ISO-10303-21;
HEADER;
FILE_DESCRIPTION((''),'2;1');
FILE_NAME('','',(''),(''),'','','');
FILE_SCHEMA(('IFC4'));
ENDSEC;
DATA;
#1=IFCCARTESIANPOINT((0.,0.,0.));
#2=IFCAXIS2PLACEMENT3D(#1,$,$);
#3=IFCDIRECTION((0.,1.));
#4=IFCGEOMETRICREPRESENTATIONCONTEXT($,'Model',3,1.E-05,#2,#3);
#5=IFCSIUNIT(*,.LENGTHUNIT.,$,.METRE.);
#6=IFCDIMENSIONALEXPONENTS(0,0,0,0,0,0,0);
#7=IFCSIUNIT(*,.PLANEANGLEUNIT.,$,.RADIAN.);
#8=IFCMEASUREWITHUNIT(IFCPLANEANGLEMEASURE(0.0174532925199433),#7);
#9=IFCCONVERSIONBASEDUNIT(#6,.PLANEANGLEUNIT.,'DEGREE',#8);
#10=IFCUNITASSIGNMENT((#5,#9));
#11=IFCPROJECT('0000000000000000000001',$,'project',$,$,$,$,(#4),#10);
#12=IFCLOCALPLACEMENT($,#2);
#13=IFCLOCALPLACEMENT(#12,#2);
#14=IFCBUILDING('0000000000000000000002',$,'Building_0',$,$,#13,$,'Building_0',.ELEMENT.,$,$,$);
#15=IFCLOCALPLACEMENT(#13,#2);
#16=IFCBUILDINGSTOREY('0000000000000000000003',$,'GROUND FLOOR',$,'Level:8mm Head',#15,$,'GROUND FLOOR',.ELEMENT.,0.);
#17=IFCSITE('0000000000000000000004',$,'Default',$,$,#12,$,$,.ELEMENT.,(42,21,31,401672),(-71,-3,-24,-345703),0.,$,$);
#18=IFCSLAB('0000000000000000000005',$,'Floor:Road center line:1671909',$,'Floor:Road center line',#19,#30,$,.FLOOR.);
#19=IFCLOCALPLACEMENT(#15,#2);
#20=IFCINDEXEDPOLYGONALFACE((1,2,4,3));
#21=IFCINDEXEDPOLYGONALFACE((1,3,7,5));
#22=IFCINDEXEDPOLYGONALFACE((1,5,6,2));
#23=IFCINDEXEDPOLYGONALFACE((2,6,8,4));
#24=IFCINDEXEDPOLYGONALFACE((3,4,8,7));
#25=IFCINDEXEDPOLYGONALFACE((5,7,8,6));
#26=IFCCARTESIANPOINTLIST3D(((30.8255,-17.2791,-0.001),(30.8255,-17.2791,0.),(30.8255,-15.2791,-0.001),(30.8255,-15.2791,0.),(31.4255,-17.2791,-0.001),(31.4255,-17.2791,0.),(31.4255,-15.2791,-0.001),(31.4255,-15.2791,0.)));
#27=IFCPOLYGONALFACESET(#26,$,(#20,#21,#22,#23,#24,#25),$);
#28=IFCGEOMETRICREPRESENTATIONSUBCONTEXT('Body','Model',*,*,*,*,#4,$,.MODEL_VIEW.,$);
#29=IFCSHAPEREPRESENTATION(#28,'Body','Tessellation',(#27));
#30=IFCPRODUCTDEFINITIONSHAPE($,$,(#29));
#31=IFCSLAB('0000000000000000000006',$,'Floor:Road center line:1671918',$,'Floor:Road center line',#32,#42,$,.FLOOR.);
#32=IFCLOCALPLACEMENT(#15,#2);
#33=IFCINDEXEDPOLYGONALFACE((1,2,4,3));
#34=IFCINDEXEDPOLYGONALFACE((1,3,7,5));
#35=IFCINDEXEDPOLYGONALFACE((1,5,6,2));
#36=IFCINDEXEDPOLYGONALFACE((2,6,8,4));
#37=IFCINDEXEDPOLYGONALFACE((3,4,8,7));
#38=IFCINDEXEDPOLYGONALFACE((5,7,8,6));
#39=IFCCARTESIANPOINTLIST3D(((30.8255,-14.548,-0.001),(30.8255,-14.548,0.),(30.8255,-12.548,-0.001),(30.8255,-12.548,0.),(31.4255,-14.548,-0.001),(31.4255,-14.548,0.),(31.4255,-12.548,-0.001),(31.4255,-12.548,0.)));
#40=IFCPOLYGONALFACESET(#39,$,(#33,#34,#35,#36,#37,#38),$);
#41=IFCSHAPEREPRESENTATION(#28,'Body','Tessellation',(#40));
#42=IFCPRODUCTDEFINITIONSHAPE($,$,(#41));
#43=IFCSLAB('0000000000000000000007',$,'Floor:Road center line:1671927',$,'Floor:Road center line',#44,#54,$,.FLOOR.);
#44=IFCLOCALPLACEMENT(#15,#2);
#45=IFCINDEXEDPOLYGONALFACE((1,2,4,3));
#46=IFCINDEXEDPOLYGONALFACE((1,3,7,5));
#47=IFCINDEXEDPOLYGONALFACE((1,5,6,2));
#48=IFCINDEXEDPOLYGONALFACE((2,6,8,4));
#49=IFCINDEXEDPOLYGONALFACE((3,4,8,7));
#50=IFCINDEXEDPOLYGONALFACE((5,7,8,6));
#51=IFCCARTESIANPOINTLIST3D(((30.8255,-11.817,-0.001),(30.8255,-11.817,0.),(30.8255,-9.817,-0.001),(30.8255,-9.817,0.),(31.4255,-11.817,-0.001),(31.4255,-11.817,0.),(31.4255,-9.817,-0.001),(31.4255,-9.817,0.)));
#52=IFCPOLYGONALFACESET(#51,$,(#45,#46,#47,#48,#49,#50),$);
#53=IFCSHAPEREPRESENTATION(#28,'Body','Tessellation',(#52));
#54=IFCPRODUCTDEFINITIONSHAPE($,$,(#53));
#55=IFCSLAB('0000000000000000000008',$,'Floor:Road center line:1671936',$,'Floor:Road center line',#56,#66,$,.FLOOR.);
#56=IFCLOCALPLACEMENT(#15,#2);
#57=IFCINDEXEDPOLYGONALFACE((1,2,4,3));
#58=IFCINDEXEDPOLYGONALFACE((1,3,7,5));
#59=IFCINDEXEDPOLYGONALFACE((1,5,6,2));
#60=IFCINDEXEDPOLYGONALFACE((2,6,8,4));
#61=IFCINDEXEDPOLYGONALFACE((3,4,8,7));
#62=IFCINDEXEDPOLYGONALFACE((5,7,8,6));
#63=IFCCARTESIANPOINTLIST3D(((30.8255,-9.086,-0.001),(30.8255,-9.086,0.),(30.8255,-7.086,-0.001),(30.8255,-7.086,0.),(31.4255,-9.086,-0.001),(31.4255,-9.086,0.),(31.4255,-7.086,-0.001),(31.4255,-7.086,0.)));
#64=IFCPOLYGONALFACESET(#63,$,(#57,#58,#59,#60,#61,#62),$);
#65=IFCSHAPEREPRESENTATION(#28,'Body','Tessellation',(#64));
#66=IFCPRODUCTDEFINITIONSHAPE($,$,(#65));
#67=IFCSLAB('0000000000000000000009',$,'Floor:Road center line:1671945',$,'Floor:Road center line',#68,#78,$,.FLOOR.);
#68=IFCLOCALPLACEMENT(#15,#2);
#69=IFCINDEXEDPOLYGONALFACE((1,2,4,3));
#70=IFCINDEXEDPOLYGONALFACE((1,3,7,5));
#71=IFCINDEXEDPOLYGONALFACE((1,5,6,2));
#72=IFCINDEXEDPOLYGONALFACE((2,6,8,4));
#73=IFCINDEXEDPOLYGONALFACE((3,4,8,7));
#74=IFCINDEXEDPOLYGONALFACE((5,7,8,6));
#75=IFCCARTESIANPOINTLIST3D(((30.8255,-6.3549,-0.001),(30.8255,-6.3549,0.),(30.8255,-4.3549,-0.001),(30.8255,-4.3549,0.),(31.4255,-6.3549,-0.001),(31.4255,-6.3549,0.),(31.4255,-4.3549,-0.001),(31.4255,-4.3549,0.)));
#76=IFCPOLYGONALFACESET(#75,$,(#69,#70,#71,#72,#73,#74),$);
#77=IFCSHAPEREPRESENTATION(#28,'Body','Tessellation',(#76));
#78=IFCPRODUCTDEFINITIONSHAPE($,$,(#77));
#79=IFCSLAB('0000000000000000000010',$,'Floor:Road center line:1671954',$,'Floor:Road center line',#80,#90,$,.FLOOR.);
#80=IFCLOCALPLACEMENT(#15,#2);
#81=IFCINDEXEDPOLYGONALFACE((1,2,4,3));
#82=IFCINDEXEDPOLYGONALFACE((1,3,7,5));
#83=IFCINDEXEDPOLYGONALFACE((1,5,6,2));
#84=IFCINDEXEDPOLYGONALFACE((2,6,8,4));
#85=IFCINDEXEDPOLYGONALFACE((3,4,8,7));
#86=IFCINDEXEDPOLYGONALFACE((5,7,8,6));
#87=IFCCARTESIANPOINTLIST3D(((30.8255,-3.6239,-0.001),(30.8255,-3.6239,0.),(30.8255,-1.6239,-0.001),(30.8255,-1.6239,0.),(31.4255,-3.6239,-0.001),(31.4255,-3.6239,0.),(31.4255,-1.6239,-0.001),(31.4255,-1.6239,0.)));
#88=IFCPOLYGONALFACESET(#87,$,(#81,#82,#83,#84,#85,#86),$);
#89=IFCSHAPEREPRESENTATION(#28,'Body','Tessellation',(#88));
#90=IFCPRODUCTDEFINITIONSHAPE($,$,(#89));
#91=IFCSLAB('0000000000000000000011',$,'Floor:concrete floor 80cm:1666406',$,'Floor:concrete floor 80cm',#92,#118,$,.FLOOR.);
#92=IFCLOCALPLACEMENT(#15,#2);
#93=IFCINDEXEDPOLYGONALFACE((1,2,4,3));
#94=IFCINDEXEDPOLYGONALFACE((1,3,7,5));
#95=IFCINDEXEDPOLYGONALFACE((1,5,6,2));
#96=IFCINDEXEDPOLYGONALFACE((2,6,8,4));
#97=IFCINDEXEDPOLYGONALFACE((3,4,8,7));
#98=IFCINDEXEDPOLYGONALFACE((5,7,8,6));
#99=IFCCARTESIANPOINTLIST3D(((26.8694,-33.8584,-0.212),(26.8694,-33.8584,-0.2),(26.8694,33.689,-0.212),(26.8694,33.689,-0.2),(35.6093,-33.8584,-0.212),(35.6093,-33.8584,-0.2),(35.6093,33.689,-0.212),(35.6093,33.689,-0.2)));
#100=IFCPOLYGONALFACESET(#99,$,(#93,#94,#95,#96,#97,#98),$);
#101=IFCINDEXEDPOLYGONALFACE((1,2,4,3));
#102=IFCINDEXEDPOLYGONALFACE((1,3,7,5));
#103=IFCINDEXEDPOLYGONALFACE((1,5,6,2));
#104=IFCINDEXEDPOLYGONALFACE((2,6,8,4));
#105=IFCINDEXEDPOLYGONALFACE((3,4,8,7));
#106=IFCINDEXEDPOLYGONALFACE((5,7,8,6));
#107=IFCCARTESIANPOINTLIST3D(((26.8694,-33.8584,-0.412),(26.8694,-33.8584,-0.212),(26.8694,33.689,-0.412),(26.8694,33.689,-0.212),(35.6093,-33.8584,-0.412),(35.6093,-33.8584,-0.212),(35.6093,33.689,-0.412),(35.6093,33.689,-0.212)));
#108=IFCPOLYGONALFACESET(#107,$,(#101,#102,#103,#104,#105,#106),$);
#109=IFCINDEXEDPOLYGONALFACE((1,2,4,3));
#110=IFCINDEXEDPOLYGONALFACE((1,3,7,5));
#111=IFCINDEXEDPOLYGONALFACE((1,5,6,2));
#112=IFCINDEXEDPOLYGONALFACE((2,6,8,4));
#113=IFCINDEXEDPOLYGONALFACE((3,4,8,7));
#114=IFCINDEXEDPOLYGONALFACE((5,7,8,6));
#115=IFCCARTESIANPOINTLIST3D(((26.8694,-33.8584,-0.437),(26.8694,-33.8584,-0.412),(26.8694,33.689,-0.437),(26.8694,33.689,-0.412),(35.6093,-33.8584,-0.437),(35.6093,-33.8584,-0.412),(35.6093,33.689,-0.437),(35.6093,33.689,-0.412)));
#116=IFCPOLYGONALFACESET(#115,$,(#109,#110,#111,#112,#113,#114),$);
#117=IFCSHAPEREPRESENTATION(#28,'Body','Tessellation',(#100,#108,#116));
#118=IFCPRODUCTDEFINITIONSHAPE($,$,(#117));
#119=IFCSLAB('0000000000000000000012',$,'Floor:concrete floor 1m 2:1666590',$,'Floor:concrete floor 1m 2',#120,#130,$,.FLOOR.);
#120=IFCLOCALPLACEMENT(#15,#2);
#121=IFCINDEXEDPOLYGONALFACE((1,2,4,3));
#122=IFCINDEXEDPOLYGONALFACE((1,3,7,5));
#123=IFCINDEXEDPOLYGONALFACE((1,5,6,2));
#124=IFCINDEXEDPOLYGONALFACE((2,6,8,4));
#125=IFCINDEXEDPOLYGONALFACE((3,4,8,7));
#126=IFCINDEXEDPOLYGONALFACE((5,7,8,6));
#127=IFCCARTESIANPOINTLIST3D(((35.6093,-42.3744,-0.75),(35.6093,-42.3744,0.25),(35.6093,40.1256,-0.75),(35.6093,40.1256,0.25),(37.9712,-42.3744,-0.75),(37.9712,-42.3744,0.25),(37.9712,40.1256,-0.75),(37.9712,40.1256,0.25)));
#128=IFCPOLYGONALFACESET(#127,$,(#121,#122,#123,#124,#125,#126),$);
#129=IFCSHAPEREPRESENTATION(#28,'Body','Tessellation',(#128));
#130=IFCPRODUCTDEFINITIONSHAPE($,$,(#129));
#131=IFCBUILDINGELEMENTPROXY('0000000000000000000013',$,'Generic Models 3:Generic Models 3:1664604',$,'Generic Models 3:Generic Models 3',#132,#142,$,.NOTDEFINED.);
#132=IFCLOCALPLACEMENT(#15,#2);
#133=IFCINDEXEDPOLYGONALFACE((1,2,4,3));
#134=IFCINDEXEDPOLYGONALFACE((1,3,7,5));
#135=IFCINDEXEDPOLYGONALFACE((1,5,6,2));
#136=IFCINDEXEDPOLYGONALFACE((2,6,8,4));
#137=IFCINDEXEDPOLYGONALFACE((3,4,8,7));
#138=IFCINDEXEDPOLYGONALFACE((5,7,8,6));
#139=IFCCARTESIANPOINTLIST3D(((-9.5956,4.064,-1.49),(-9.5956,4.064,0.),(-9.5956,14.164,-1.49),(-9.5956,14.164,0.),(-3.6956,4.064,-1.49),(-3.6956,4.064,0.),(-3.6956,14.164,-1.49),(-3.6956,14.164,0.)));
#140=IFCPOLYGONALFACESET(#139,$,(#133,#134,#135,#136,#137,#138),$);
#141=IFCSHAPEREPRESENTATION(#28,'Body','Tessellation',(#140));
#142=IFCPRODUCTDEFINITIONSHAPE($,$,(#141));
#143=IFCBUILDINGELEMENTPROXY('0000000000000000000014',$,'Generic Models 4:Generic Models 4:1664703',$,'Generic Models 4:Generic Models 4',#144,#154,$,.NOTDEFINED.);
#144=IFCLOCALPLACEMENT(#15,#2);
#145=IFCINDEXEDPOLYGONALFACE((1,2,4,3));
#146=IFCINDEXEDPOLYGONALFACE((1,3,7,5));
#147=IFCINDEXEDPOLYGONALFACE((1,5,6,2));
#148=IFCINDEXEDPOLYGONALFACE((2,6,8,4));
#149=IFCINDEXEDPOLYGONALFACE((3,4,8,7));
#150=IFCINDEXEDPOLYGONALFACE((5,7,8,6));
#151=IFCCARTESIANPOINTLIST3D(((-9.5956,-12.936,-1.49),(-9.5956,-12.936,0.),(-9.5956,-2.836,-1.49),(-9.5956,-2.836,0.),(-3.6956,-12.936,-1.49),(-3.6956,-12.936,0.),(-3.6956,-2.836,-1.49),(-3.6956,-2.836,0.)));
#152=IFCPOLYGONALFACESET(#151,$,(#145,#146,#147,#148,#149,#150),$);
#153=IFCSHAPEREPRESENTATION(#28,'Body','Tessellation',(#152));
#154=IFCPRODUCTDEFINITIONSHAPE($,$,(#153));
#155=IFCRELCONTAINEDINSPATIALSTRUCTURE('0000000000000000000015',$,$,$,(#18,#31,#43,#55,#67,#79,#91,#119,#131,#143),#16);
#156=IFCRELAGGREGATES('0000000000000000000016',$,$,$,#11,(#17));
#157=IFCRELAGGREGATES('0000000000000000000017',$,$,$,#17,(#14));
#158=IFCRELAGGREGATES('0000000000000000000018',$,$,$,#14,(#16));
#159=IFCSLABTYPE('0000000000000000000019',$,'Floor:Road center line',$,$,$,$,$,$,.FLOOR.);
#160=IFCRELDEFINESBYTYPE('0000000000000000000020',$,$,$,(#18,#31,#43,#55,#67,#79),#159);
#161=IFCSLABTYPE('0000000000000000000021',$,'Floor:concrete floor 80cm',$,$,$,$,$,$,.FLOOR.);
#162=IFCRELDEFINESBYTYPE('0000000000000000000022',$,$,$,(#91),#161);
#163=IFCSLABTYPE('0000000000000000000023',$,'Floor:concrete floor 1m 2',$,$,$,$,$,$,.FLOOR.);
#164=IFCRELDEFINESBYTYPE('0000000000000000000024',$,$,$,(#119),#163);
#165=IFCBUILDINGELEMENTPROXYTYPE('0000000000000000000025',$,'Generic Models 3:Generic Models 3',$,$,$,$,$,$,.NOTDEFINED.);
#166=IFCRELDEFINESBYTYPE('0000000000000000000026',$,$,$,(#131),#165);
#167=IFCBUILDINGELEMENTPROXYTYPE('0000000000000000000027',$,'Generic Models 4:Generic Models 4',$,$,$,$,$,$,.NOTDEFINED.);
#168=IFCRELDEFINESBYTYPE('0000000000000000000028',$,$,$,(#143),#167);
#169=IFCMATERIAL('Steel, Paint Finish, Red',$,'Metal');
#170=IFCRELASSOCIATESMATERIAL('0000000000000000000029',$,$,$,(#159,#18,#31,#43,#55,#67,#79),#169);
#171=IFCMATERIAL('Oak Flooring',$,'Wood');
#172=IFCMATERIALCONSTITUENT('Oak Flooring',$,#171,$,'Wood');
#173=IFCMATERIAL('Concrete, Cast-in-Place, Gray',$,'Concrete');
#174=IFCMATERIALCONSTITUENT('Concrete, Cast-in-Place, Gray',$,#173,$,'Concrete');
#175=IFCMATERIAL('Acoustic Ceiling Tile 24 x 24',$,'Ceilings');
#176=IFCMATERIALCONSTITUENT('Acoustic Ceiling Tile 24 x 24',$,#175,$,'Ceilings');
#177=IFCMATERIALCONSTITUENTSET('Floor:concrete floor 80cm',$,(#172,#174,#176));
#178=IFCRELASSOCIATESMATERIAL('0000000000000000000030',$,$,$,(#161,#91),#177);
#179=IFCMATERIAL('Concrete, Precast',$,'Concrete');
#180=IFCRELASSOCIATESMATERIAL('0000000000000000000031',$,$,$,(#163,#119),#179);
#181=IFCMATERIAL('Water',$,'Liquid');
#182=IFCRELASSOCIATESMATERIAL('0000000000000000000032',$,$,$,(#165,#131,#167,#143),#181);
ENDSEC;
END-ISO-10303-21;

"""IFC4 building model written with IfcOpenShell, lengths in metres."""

from ifc_helpers import new_model, entity, si_unit, converted_unit, direction, frame, origin, place, context, subcontext, project, spatial, indexed_curve, outline, extrude, source, transform, mapped, material, constituent, constituent_set, type_object, type_shapes, element, save


model = new_model("IFC4")

# Units and contexts
model_context = context("Model", 3, precision=1e-05, world=origin(), true_north=direction((0.0, 1.0)))
body_context = subcontext(model_context, "Body", "Model", "MODEL_VIEW")
ifc_project = project(units=[si_unit("LENGTHUNIT", "METRE"), converted_unit("PLANEANGLEUNIT", "DEGREE", entity("IfcPlaneAngleMeasure", 0.0174532925199433), si_unit("PLANEANGLEUNIT", "RADIAN"), dimensions=[0, 0, 0, 0, 0, 0, 0])], contexts=[model_context])

# Site, building, storey
site_placement = place(None, origin())
site = spatial("IfcSite", under=ifc_project, at=site_placement, Name="Default", CompositionType="ELEMENT", RefLatitude=(42, 21, 31, 401672), RefLongitude=(-71, -3, -24, -345703), RefElevation=0.0)
building_placement = place(site_placement, origin())
building = spatial("IfcBuilding", under=site, at=building_placement, Name="Building_0", LongName="Building_0", CompositionType="ELEMENT")
storey_placement = place(building_placement, origin())
storey = spatial("IfcBuildingStorey", under=building, at=storey_placement, Name="GROUND FLOOR", ObjectType="Level:8mm Head", LongName="GROUND FLOOR", CompositionType="ELEMENT", Elevation=0.0)

# Slabs
ifc_material_1 = material(Name="Steel, Paint Finish, Red", Category="Metal")
slab_type_1 = type_object("IfcSlabType", Name="Floor:Road center line", PredefinedType="FLOOR", material=ifc_material_1)
slab_1_placement = place(storey_placement, origin())
element("IfcSlab", 1, at=slab_1_placement, inside=storey, type_object=slab_type_1, material=ifc_material_1, Name="Floor:Road center line:1671909", ObjectType="Floor:Road center line", PredefinedType="FLOOR", context=body_context, shape_type="SweptSolid", body=[
    extrude(outline(indexed_curve([(-1.0, -0.3), (1.0, -0.3), (1.0, 0.3), (-1.0, 0.3), (-1.0, -0.3)], self_intersect=False)), frame((31.1255, -16.2791, 0.0), z_axis=(0.0, 0.0, -1.0), x_axis=(0.0, 1.0, 0.0)), (0.0, 0.0, 1.0), 0.001),
])
slab_2_placement = place(storey_placement, origin())
element("IfcSlab", 2, at=slab_2_placement, inside=storey, type_object=slab_type_1, material=ifc_material_1, Name="Floor:Road center line:1671918", ObjectType="Floor:Road center line", PredefinedType="FLOOR", context=body_context, shape_type="SweptSolid", body=[
    extrude(outline(indexed_curve([(-1.0, -0.3), (1.0, -0.3), (1.0, 0.3), (-1.0, 0.3), (-1.0, -0.3)], self_intersect=False)), frame((31.1255, -13.548, 0.0), z_axis=(0.0, 0.0, -1.0), x_axis=(0.0, 1.0, 0.0)), (0.0, 0.0, 1.0), 0.001),
])
slab_3_placement = place(storey_placement, origin())
element("IfcSlab", 3, at=slab_3_placement, inside=storey, type_object=slab_type_1, material=ifc_material_1, Name="Floor:Road center line:1671927", ObjectType="Floor:Road center line", PredefinedType="FLOOR", context=body_context, shape_type="SweptSolid", body=[
    extrude(outline(indexed_curve([(-1.0, -0.3), (1.0, -0.3), (1.0, 0.3), (-1.0, 0.3), (-1.0, -0.3)], self_intersect=False)), frame((31.1255, -10.817, 0.0), z_axis=(0.0, 0.0, -1.0), x_axis=(0.0, 1.0, 0.0)), (0.0, 0.0, 1.0), 0.001),
])
slab_4_placement = place(storey_placement, origin())
element("IfcSlab", 4, at=slab_4_placement, inside=storey, type_object=slab_type_1, material=ifc_material_1, Name="Floor:Road center line:1671936", ObjectType="Floor:Road center line", PredefinedType="FLOOR", context=body_context, shape_type="SweptSolid", body=[
    extrude(outline(indexed_curve([(-1.0, -0.3), (1.0, -0.3), (1.0, 0.3), (-1.0, 0.3), (-1.0, -0.3)], self_intersect=False)), frame((31.1255, -8.086, 0.0), z_axis=(0.0, 0.0, -1.0), x_axis=(0.0, 1.0, 0.0)), (0.0, 0.0, 1.0), 0.001),
])
slab_5_placement = place(storey_placement, origin())
element("IfcSlab", 5, at=slab_5_placement, inside=storey, type_object=slab_type_1, material=ifc_material_1, Name="Floor:Road center line:1671945", ObjectType="Floor:Road center line", PredefinedType="FLOOR", context=body_context, shape_type="SweptSolid", body=[
    extrude(outline(indexed_curve([(-1.0, -0.3), (1.0, -0.3), (1.0, 0.3), (-1.0, 0.3), (-1.0, -0.3)], self_intersect=False)), frame((31.1255, -5.3549, 0.0), z_axis=(0.0, 0.0, -1.0), x_axis=(0.0, 1.0, 0.0)), (0.0, 0.0, 1.0), 0.001),
])
slab_6_placement = place(storey_placement, origin())
element("IfcSlab", 6, at=slab_6_placement, inside=storey, type_object=slab_type_1, material=ifc_material_1, Name="Floor:Road center line:1671954", ObjectType="Floor:Road center line", PredefinedType="FLOOR", context=body_context, shape_type="SweptSolid", body=[
    extrude(outline(indexed_curve([(-1.0, -0.3), (1.0, -0.3), (1.0, 0.3), (-1.0, 0.3), (-1.0, -0.3)], self_intersect=False)), frame((31.1255, -2.6239, 0.0), z_axis=(0.0, 0.0, -1.0), x_axis=(0.0, 1.0, 0.0)), (0.0, 0.0, 1.0), 0.001),
])
ifc_material_2 = material(Name="Oak Flooring", Category="Wood")
ifc_constituent_1 = constituent(ifc_material_2, Name="Oak Flooring", Category="Wood")
ifc_material_3 = material(Name="Concrete, Cast-in-Place, Gray", Category="Concrete")
ifc_constituent_2 = constituent(ifc_material_3, Name="Concrete, Cast-in-Place, Gray", Category="Concrete")
ifc_material_4 = material(Name="Acoustic Ceiling Tile 24 x 24", Category="Ceilings")
ifc_constituent_3 = constituent(ifc_material_4, Name="Acoustic Ceiling Tile 24 x 24", Category="Ceilings")
ifc_constituent_set = constituent_set(constituents=[ifc_constituent_1, ifc_constituent_2, ifc_constituent_3], Name="Floor:concrete floor 80cm")
slab_type_2 = type_object("IfcSlabType", Name="Floor:concrete floor 80cm", PredefinedType="FLOOR", material=ifc_constituent_set)
slab_7_placement = place(storey_placement, origin())
element("IfcSlab", 7, at=slab_7_placement, inside=storey, type_object=slab_type_2, material=ifc_constituent_set, Name="Floor:concrete floor 80cm:1666406", ObjectType="Floor:concrete floor 80cm", PredefinedType="FLOOR", context=body_context, shape_type="SweptSolid", body=[
    extrude(outline(indexed_curve([(-4.37, -33.7737), (4.37, -33.7737), (4.37, 33.7737), (-4.37, 33.7737), (-4.37, -33.7737)], self_intersect=False)), frame((31.2394, -0.0847, -0.212), z_axis=(0.0, 0.0, 1.0), x_axis=(-1.0, 0.0, 0.0)), (0.0, 0.0, 1.0), 0.012),
    extrude(outline(indexed_curve([(-4.37, -33.7737), (4.37, -33.7737), (4.37, 33.7737), (-4.37, 33.7737), (-4.37, -33.7737)], self_intersect=False)), frame((31.2394, -0.0847, -0.412), z_axis=(0.0, 0.0, 1.0), x_axis=(-1.0, 0.0, 0.0)), (0.0, 0.0, 1.0), 0.2),
    extrude(outline(indexed_curve([(-4.37, -33.7737), (4.37, -33.7737), (4.37, 33.7737), (-4.37, 33.7737), (-4.37, -33.7737)], self_intersect=False)), frame((31.2394, -0.0847, -0.437), z_axis=(0.0, 0.0, 1.0), x_axis=(-1.0, 0.0, 0.0)), (0.0, 0.0, 1.0), 0.025),
])
ifc_material_5 = material(Name="Concrete, Precast", Category="Concrete")
slab_type_3 = type_object("IfcSlabType", Name="Floor:concrete floor 1m 2", PredefinedType="FLOOR", material=ifc_material_5)
slab_8_placement = place(storey_placement, origin())
element("IfcSlab", 8, at=slab_8_placement, inside=storey, type_object=slab_type_3, material=ifc_material_5, Name="Floor:concrete floor 1m 2:1666590", ObjectType="Floor:concrete floor 1m 2", PredefinedType="FLOOR", context=body_context, shape_type="SweptSolid", body=[
    extrude(outline(indexed_curve([(-41.25, -1.1809), (41.25, -1.1809), (41.25, 1.1809), (-41.25, 1.1809), (-41.25, -1.1809)], self_intersect=False)), frame((36.7902, -1.1244, 0.25), z_axis=(0.0, 0.0, -1.0), x_axis=(0.0, 1.0, 0.0)), (0.0, 0.0, 1.0), 1.0),
])

# Building element proxies
ifc_material_6 = material(Name="Water", Category="Liquid")
building_element_proxy_type_1 = type_object("IfcBuildingElementProxyType", Name="Generic Models 3:Generic Models 3", PredefinedType="NOTDEFINED", material=ifc_material_6)
shared_shape_1 = source(origin(), body_context, "Body", "SweptSolid", [
    extrude(outline(indexed_curve([(-2.95, -5.05), (2.95, -5.05), (2.95, 5.05), (-2.95, 5.05), (-2.95, -5.05)], self_intersect=False)), frame((-6.6456, 9.114, -1.49), z_axis=(0.0, 0.0, 1.0), x_axis=(-1.0, 0.0, 0.0)), (0.0, 0.0, 1.0), 1.49),
])
type_shapes(building_element_proxy_type_1, [shared_shape_1])
proxy_1_placement = place(storey_placement, origin())
element("IfcBuildingElementProxy", 9, at=proxy_1_placement, inside=storey, type_object=building_element_proxy_type_1, material=ifc_material_6, Name="Generic Models 3:Generic Models 3:1664604", ObjectType="Generic Models 3:Generic Models 3", PredefinedType="NOTDEFINED", context=body_context, shape_type="MappedRepresentation", body=[
    mapped(shared_shape_1, transform((0.0, 0.0, 0.0), scale=1.0)),
])
building_element_proxy_type_2 = type_object("IfcBuildingElementProxyType", Name="Generic Models 4:Generic Models 4", PredefinedType="NOTDEFINED", material=ifc_material_6)
shared_shape_2 = source(origin(), body_context, "Body", "SweptSolid", [
    extrude(outline(indexed_curve([(-2.95, -5.05), (2.95, -5.05), (2.95, 5.05), (-2.95, 5.05), (-2.95, -5.05)], self_intersect=False)), frame((-6.6456, -7.886, -1.49), z_axis=(0.0, 0.0, 1.0), x_axis=(-1.0, 0.0, 0.0)), (0.0, 0.0, 1.0), 1.49),
])
type_shapes(building_element_proxy_type_2, [shared_shape_2])
proxy_2_placement = place(storey_placement, origin())
element("IfcBuildingElementProxy", 10, at=proxy_2_placement, inside=storey, type_object=building_element_proxy_type_2, material=ifc_material_6, Name="Generic Models 4:Generic Models 4:1664703", ObjectType="Generic Models 4:Generic Models 4", PredefinedType="NOTDEFINED", context=body_context, shape_type="MappedRepresentation", body=[
    mapped(shared_shape_2, transform((0.0, 0.0, 0.0), scale=1.0)),
])

save(model, "model.ifc")
